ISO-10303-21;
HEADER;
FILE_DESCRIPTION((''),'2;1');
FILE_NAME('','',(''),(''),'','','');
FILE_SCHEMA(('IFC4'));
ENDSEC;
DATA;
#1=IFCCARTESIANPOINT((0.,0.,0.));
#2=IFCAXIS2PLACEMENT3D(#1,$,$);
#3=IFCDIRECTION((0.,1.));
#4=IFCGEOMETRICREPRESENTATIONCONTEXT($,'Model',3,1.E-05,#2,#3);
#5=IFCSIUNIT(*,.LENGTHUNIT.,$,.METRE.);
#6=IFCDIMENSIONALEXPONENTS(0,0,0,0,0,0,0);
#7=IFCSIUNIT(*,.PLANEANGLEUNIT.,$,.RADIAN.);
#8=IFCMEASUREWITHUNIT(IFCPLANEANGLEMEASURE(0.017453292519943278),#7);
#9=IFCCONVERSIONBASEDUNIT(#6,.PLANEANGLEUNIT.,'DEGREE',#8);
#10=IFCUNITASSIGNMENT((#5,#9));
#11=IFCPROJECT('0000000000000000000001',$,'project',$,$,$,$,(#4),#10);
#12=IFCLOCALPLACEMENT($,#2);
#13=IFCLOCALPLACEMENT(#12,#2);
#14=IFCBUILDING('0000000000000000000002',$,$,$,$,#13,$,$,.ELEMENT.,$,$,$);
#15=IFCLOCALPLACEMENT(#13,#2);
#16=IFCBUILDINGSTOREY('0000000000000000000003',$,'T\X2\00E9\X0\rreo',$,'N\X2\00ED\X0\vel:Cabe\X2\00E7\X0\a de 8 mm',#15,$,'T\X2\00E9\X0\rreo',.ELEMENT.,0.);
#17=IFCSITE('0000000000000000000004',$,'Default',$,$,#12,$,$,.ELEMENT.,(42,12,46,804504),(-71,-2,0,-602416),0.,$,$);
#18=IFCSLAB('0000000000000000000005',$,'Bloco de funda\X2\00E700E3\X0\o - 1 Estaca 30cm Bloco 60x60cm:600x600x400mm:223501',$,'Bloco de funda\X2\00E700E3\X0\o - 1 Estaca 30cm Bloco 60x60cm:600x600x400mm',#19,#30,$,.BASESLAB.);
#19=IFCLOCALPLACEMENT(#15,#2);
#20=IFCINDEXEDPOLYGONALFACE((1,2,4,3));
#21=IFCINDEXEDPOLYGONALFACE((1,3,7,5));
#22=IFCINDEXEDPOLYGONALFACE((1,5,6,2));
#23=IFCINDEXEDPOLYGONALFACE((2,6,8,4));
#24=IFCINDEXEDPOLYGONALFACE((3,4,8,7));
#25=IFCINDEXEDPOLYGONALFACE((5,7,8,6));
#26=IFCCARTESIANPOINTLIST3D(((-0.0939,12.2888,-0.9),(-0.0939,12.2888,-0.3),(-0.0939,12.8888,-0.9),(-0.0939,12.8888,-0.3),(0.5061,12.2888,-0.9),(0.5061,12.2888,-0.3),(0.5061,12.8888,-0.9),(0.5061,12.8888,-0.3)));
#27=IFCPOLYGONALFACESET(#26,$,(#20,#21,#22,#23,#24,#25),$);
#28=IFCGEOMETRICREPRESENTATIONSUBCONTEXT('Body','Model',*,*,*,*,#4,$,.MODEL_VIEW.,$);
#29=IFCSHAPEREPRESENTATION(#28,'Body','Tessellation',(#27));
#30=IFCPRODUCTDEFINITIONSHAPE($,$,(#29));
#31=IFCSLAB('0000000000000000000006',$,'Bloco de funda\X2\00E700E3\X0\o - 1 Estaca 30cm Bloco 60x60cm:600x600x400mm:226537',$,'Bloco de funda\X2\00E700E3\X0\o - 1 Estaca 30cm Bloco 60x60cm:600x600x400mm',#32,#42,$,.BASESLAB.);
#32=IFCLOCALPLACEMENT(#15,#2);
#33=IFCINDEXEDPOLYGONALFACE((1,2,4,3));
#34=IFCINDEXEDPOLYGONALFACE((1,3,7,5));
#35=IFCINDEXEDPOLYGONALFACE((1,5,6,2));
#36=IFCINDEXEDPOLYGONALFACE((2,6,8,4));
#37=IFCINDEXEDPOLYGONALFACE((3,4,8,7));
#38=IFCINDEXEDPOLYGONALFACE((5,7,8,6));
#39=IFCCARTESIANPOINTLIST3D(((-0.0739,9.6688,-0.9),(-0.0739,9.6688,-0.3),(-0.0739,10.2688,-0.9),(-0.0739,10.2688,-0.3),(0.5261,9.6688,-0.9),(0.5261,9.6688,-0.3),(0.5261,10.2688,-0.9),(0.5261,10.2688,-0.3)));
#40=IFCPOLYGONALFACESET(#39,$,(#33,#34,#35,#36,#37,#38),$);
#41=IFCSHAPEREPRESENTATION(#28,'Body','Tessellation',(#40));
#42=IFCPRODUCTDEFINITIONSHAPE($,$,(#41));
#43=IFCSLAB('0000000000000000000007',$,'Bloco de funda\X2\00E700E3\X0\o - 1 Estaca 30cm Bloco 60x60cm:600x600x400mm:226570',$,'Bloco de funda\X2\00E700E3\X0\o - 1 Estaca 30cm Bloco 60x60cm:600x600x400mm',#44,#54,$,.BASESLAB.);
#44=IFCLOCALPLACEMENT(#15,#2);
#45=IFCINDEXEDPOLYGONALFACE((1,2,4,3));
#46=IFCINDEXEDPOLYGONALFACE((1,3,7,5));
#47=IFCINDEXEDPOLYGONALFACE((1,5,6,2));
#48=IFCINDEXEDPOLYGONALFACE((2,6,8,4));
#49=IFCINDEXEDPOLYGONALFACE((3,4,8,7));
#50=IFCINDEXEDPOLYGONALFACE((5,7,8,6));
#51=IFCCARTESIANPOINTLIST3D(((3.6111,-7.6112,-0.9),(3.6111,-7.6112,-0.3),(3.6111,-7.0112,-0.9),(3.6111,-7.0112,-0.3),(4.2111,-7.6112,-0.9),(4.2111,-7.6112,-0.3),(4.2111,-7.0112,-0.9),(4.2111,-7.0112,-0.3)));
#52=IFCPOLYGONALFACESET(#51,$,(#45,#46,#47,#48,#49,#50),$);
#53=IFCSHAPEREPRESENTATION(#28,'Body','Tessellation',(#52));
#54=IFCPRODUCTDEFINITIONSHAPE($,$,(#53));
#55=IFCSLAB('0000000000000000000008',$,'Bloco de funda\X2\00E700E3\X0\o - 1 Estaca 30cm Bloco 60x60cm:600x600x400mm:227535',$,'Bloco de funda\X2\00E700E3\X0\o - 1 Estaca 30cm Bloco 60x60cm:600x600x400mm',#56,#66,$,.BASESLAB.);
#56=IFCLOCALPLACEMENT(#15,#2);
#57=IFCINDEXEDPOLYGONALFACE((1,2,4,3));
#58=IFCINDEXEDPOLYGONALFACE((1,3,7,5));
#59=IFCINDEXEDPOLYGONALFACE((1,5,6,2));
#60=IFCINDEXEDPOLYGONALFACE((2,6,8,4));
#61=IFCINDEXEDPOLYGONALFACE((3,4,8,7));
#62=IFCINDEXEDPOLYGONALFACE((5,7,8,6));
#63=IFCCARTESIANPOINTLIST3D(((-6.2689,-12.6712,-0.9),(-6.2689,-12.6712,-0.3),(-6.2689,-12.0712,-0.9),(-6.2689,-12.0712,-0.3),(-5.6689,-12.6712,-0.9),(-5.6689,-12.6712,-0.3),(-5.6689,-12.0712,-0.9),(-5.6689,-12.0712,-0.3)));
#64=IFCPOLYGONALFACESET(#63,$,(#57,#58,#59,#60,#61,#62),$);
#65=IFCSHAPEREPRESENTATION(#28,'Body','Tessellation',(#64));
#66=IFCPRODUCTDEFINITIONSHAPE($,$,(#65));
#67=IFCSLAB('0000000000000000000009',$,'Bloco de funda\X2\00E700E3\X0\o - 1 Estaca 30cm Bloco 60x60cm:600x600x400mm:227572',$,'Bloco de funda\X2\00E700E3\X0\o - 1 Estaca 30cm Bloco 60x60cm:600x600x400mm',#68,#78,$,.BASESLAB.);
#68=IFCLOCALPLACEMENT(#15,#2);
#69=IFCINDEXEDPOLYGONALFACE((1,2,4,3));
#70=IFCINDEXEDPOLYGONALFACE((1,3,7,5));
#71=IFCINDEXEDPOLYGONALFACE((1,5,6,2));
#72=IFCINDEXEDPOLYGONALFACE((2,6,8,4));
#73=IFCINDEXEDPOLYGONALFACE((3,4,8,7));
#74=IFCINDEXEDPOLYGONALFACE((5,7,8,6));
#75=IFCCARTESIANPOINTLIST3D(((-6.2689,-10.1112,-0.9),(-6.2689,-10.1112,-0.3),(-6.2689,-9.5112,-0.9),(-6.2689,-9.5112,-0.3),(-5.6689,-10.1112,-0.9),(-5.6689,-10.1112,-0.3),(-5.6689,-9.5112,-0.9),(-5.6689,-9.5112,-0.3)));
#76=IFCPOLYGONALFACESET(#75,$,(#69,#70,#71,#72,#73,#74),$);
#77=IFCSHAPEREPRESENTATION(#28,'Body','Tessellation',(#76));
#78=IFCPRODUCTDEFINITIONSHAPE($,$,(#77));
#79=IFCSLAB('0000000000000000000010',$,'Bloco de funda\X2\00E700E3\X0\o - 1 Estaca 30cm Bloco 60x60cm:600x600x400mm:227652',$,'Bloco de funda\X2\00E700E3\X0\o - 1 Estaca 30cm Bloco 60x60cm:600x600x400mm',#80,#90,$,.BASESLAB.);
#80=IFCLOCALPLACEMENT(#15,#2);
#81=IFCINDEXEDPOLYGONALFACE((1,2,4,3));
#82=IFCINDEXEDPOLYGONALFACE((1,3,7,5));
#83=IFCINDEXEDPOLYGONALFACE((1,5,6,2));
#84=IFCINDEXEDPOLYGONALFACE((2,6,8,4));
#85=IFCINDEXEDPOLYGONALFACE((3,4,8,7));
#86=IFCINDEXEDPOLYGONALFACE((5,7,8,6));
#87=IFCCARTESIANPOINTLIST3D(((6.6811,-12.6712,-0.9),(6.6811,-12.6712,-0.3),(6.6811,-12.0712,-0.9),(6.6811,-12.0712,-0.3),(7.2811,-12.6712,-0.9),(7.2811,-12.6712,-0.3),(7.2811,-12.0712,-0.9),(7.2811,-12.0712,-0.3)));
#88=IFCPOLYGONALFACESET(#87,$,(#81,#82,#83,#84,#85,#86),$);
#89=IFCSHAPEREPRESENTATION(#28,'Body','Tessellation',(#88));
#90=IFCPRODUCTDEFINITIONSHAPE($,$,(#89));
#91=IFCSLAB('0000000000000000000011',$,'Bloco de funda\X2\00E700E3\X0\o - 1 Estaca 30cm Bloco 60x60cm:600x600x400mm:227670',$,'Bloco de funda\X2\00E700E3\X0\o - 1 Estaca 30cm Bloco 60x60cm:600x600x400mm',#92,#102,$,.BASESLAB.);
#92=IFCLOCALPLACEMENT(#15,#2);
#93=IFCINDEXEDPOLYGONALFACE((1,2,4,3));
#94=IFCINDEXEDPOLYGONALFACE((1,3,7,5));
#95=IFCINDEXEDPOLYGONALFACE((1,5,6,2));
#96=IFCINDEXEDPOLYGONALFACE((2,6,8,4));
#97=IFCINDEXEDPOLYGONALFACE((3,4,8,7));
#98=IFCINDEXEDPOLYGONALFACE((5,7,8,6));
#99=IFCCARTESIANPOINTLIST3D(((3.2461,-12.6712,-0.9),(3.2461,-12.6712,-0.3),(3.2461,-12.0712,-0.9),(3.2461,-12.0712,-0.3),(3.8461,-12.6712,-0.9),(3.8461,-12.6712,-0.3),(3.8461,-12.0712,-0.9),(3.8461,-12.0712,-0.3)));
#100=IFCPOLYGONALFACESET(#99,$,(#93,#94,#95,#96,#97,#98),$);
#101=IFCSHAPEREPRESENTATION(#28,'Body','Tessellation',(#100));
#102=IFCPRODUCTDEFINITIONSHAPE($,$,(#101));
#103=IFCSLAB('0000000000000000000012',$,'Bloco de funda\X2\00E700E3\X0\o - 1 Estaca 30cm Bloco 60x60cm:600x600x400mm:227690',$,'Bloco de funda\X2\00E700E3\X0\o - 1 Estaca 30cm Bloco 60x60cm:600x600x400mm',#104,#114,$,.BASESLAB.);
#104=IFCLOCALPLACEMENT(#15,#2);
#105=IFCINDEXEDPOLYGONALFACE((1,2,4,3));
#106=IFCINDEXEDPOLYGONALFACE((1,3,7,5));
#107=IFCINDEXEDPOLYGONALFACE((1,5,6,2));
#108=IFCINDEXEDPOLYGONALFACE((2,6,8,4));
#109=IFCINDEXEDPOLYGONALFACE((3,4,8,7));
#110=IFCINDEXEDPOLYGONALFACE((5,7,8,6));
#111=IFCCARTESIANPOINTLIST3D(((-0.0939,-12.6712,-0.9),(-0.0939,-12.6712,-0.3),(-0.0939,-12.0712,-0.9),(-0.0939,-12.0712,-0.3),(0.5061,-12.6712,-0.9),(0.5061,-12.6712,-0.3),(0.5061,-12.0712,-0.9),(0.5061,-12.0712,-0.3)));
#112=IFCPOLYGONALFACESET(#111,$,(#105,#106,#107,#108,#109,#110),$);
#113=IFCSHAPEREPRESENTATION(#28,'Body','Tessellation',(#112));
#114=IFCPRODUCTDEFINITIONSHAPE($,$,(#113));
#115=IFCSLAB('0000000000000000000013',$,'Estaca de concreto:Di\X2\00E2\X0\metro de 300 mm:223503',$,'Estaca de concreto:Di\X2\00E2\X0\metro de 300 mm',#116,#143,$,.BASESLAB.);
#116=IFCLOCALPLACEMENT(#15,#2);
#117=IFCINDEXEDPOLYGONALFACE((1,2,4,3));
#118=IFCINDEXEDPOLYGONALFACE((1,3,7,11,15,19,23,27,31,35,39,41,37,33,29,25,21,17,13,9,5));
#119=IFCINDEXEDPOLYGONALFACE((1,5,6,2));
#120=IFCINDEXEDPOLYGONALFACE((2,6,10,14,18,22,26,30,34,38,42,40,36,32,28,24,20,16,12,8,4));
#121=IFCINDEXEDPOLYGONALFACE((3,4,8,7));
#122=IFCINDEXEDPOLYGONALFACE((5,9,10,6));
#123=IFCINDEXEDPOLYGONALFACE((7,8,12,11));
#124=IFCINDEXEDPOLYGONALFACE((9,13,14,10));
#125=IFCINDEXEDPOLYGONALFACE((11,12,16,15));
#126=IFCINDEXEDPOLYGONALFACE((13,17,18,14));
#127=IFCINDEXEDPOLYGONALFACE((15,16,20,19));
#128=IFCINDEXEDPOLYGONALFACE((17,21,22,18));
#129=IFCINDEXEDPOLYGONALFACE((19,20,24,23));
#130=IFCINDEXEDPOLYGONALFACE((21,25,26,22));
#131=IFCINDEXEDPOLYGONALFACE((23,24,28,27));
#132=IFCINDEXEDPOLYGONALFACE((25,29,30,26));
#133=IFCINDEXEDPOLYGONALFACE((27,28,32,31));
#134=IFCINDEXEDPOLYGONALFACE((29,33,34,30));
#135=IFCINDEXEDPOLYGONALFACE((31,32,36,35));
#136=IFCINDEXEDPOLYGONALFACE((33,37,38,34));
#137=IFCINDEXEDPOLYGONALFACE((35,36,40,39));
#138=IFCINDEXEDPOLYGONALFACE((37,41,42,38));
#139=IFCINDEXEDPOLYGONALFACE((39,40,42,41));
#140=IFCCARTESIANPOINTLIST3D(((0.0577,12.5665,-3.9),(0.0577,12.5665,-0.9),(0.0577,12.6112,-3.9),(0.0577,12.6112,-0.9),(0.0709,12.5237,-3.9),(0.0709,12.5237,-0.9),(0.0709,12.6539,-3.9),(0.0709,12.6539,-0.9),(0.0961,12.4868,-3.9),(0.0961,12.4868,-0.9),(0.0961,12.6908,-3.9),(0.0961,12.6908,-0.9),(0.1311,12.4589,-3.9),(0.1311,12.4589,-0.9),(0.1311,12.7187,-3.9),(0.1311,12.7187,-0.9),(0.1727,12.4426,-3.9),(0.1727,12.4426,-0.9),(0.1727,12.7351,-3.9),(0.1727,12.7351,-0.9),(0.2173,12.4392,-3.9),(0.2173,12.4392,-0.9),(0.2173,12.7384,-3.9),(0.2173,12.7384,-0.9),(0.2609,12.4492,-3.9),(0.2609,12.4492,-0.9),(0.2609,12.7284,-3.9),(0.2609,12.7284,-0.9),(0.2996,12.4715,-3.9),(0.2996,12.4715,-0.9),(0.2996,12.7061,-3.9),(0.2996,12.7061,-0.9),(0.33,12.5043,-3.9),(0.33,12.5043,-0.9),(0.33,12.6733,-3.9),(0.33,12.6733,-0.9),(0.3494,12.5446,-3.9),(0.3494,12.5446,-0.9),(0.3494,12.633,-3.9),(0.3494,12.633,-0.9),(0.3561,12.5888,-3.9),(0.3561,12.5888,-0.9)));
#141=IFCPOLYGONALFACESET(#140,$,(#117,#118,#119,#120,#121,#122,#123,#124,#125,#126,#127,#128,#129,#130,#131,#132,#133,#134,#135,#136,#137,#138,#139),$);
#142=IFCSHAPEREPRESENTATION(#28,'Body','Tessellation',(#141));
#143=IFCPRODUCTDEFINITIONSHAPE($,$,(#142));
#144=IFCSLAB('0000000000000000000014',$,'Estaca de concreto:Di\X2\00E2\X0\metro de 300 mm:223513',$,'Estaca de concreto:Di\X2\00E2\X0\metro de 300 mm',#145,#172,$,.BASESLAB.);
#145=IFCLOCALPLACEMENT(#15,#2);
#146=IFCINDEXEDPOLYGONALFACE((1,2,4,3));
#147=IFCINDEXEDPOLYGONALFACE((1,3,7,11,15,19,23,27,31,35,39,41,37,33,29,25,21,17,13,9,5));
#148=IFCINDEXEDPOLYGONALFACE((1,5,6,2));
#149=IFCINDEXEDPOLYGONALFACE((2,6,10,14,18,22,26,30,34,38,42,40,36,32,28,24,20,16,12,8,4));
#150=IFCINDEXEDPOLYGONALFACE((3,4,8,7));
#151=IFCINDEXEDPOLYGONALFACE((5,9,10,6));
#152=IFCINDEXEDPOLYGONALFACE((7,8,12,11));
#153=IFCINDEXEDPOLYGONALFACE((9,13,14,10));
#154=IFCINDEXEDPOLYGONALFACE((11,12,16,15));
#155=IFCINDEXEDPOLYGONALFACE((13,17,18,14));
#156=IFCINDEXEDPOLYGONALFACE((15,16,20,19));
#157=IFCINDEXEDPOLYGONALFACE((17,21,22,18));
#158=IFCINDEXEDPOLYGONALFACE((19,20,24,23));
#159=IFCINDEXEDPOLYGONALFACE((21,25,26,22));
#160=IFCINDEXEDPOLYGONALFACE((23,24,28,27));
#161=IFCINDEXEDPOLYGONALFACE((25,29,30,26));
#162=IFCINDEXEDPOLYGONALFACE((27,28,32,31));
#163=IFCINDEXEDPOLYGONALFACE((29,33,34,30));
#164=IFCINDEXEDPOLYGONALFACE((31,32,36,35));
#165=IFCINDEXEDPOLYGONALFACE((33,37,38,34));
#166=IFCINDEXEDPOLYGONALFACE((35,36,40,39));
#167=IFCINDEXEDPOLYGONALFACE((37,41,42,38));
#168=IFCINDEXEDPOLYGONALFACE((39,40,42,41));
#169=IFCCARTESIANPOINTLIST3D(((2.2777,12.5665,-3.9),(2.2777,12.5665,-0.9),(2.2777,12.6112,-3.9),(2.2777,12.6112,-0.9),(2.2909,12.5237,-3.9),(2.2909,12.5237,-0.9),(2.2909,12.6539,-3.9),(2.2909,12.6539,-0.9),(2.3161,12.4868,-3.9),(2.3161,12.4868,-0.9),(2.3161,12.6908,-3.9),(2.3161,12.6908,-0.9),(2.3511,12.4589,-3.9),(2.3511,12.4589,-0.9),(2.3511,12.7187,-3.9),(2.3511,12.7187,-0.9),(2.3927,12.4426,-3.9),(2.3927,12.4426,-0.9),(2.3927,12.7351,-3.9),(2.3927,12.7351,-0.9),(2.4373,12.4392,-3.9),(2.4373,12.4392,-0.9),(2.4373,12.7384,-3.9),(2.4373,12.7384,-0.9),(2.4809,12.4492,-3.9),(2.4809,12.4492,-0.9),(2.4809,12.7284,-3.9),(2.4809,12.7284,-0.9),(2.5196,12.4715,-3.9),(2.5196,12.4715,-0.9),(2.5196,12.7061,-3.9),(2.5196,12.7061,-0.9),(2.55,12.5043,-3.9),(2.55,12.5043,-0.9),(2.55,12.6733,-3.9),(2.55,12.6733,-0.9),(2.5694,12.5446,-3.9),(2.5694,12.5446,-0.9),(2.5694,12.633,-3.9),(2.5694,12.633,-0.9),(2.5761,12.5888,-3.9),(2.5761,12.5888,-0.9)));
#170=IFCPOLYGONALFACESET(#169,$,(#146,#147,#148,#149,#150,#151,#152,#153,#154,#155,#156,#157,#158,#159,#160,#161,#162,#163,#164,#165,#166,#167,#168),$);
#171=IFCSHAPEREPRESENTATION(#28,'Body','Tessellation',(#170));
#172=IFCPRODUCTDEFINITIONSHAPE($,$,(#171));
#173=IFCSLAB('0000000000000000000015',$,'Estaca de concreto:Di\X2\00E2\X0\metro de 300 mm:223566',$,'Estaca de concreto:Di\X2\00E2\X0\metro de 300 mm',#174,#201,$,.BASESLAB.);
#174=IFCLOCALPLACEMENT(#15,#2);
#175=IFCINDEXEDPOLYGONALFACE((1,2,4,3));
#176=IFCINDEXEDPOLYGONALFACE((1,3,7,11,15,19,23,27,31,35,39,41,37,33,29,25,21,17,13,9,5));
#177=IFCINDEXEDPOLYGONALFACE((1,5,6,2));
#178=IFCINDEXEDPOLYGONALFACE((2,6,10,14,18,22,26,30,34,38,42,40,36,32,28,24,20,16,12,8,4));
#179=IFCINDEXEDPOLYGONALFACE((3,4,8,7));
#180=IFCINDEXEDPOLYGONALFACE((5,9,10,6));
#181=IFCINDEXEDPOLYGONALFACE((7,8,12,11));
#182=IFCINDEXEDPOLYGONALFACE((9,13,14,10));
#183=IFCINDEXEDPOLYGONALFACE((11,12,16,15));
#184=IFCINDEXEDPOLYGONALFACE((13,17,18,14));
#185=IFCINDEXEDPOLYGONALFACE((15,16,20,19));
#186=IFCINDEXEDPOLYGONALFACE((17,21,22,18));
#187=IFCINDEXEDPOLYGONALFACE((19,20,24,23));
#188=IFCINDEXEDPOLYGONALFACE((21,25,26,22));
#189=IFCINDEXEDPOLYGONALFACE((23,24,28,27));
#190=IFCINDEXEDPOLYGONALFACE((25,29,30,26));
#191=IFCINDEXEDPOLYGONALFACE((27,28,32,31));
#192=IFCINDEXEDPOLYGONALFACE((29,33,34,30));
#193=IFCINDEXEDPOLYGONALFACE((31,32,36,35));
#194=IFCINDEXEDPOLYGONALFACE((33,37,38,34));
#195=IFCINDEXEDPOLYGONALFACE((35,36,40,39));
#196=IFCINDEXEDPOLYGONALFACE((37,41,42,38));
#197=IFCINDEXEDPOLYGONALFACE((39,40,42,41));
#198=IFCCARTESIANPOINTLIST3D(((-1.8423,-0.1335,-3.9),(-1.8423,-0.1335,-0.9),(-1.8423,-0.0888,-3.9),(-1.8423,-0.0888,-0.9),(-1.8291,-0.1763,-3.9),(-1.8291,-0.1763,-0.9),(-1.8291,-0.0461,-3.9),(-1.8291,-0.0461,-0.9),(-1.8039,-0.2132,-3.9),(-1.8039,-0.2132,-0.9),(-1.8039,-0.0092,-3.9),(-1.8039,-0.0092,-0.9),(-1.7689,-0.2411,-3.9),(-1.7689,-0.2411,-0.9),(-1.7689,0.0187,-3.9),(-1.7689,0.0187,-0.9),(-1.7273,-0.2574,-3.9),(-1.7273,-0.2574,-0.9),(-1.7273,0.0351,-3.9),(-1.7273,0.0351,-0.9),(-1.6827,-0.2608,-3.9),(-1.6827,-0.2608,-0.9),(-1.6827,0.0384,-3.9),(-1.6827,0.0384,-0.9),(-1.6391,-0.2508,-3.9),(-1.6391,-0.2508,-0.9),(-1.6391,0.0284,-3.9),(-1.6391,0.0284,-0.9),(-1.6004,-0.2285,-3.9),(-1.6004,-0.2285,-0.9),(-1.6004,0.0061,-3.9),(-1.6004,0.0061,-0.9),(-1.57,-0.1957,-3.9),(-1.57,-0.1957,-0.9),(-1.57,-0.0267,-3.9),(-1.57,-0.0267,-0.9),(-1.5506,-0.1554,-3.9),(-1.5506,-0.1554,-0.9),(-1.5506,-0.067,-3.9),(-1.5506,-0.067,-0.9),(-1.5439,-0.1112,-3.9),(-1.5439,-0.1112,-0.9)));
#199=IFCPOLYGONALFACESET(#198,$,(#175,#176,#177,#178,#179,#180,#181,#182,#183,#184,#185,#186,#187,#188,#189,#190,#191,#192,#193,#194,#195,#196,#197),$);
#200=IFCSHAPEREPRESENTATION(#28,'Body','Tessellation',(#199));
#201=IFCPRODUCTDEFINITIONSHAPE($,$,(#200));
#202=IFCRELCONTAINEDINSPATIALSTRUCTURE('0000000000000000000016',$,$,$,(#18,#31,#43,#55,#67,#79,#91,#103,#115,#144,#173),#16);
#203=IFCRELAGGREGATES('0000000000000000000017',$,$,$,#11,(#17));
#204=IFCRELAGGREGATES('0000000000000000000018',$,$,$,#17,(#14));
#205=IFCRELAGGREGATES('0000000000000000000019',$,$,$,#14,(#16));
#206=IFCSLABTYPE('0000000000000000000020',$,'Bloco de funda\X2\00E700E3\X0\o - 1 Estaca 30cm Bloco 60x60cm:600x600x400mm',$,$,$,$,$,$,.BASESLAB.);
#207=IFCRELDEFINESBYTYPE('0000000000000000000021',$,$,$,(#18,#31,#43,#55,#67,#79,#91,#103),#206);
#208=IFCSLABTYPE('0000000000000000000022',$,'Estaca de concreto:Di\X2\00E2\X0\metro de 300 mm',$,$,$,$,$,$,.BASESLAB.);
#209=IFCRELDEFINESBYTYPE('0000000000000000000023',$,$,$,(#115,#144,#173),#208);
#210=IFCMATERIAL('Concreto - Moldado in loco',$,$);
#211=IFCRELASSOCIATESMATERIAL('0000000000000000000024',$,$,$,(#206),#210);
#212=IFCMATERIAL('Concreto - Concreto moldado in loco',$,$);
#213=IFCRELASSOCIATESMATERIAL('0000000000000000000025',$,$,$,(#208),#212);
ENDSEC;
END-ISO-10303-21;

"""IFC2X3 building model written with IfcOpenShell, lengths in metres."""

from ifc_helpers import new_model, entity, si_unit, converted_unit, direction, frame, frame_2d, origin, origin_2d_with_axis, place, context, subcontext, project, spatial, rectangle, circle, extrude, material, type_object, element, save


model = new_model("IFC2X3")

# Units and contexts
model_context = context("Model", 3, precision=1e-05, world=origin(), true_north=direction((0.0, 1.0)))
body_context = subcontext(model_context, "Body", "Model", "MODEL_VIEW")
ifc_project = project(units=[si_unit("LENGTHUNIT", "METRE"), converted_unit("PLANEANGLEUNIT", "DEGREE", entity("IfcPlaneAngleMeasure", 0.017453292519943278), si_unit("PLANEANGLEUNIT", "RADIAN"), dimensions=[0, 0, 0, 0, 0, 0, 0])], contexts=[model_context])

# Site, building, storey
site_placement = place(None, origin())
site = spatial("IfcSite", under=ifc_project, at=site_placement, Name="Default", CompositionType="ELEMENT", RefLatitude=(42, 12, 46, 804504), RefLongitude=(-71, -2, 0, -602416), RefElevation=0.0)
building_placement = place(site_placement, origin())
building = spatial("IfcBuilding", under=site, at=building_placement, CompositionType="ELEMENT")
storey_placement = place(building_placement, origin())
storey = spatial("IfcBuildingStorey", under=building, at=storey_placement, Name="Térreo", ObjectType="Nível:Cabeça de 8 mm", LongName="Térreo", CompositionType="ELEMENT", Elevation=0.0)

# Slabs
ifc_material_1 = material(Name="Concreto - Moldado in loco")
slab_type_1 = type_object("IfcSlabType", Name="Bloco de fundação - 1 Estaca 30cm Bloco 60x60cm:600x600x400mm", PredefinedType="BASESLAB", material=ifc_material_1)
slab_1_placement = place(storey_placement, origin())
element("IfcSlab", 1, at=slab_1_placement, inside=storey, type_object=slab_type_1, Name="Bloco de fundação - 1 Estaca 30cm Bloco 60x60cm:600x600x400mm:223501", ObjectType="Bloco de fundação - 1 Estaca 30cm Bloco 60x60cm:600x600x400mm", PredefinedType="BASESLAB", context=body_context, shape_type="SweptSolid", body=[
    extrude(rectangle(XDim=0.6, YDim=0.6, at=frame_2d((0.0, 0.0), x_axis=(1.0, 0.0))), frame((0.2061, 12.5888, -0.9), z_axis=(0.0, 0.0, 1.0), x_axis=(-1.0, 0.0, 0.0)), (0.0, 0.0, 1.0), 0.6),
])
slab_2_placement = place(storey_placement, origin())
element("IfcSlab", 2, at=slab_2_placement, inside=storey, type_object=slab_type_1, Name="Bloco de fundação - 1 Estaca 30cm Bloco 60x60cm:600x600x400mm:226537", ObjectType="Bloco de fundação - 1 Estaca 30cm Bloco 60x60cm:600x600x400mm", PredefinedType="BASESLAB", context=body_context, shape_type="SweptSolid", body=[
    extrude(rectangle(XDim=0.6, YDim=0.6, at=frame_2d((0.0, 0.0), x_axis=(1.0, 0.0))), frame((0.2261, 9.9688, -0.9), z_axis=(0.0, 0.0, 1.0), x_axis=(-1.0, 0.0, 0.0)), (0.0, 0.0, 1.0), 0.6),
])
slab_3_placement = place(storey_placement, origin())
element("IfcSlab", 3, at=slab_3_placement, inside=storey, type_object=slab_type_1, Name="Bloco de fundação - 1 Estaca 30cm Bloco 60x60cm:600x600x400mm:226570", ObjectType="Bloco de fundação - 1 Estaca 30cm Bloco 60x60cm:600x600x400mm", PredefinedType="BASESLAB", context=body_context, shape_type="SweptSolid", body=[
    extrude(rectangle(XDim=0.6, YDim=0.6, at=frame_2d((0.0, 0.0), x_axis=(1.0, 0.0))), frame((3.9111, -7.3112, -0.9), z_axis=(0.0, 0.0, 1.0), x_axis=(-1.0, 0.0, 0.0)), (0.0, 0.0, 1.0), 0.6),
])
slab_4_placement = place(storey_placement, origin())
element("IfcSlab", 4, at=slab_4_placement, inside=storey, type_object=slab_type_1, Name="Bloco de fundação - 1 Estaca 30cm Bloco 60x60cm:600x600x400mm:227535", ObjectType="Bloco de fundação - 1 Estaca 30cm Bloco 60x60cm:600x600x400mm", PredefinedType="BASESLAB", context=body_context, shape_type="SweptSolid", body=[
    extrude(rectangle(XDim=0.6, YDim=0.6, at=frame_2d((0.0, 0.0), x_axis=(1.0, 0.0))), frame((-5.9689, -12.3712, -0.9), z_axis=(0.0, 0.0, 1.0), x_axis=(-1.0, 0.0, 0.0)), (0.0, 0.0, 1.0), 0.6),
])
slab_5_placement = place(storey_placement, origin())
element("IfcSlab", 5, at=slab_5_placement, inside=storey, type_object=slab_type_1, Name="Bloco de fundação - 1 Estaca 30cm Bloco 60x60cm:600x600x400mm:227572", ObjectType="Bloco de fundação - 1 Estaca 30cm Bloco 60x60cm:600x600x400mm", PredefinedType="BASESLAB", context=body_context, shape_type="SweptSolid", body=[
    extrude(rectangle(XDim=0.6, YDim=0.6, at=frame_2d((0.0, 0.0), x_axis=(1.0, 0.0))), frame((-5.9689, -9.8112, -0.9), z_axis=(0.0, 0.0, 1.0), x_axis=(-1.0, 0.0, 0.0)), (0.0, 0.0, 1.0), 0.6),
])
slab_6_placement = place(storey_placement, origin())
element("IfcSlab", 6, at=slab_6_placement, inside=storey, type_object=slab_type_1, Name="Bloco de fundação - 1 Estaca 30cm Bloco 60x60cm:600x600x400mm:227652", ObjectType="Bloco de fundação - 1 Estaca 30cm Bloco 60x60cm:600x600x400mm", PredefinedType="BASESLAB", context=body_context, shape_type="SweptSolid", body=[
    extrude(rectangle(XDim=0.6, YDim=0.6, at=frame_2d((0.0, 0.0), x_axis=(1.0, 0.0))), frame((6.9811, -12.3712, -0.9), z_axis=(0.0, 0.0, 1.0), x_axis=(-1.0, 0.0, 0.0)), (0.0, 0.0, 1.0), 0.6),
])
slab_7_placement = place(storey_placement, origin())
element("IfcSlab", 7, at=slab_7_placement, inside=storey, type_object=slab_type_1, Name="Bloco de fundação - 1 Estaca 30cm Bloco 60x60cm:600x600x400mm:227670", ObjectType="Bloco de fundação - 1 Estaca 30cm Bloco 60x60cm:600x600x400mm", PredefinedType="BASESLAB", context=body_context, shape_type="SweptSolid", body=[
    extrude(rectangle(XDim=0.6, YDim=0.6, at=frame_2d((0.0, 0.0), x_axis=(1.0, 0.0))), frame((3.5461, -12.3712, -0.9), z_axis=(0.0, 0.0, 1.0), x_axis=(-1.0, 0.0, 0.0)), (0.0, 0.0, 1.0), 0.6),
])
slab_8_placement = place(storey_placement, origin())
element("IfcSlab", 8, at=slab_8_placement, inside=storey, type_object=slab_type_1, Name="Bloco de fundação - 1 Estaca 30cm Bloco 60x60cm:600x600x400mm:227690", ObjectType="Bloco de fundação - 1 Estaca 30cm Bloco 60x60cm:600x600x400mm", PredefinedType="BASESLAB", context=body_context, shape_type="SweptSolid", body=[
    extrude(rectangle(XDim=0.6, YDim=0.6, at=frame_2d((0.0, 0.0), x_axis=(1.0, 0.0))), frame((0.2061, -12.3712, -0.9), z_axis=(0.0, 0.0, 1.0), x_axis=(-1.0, 0.0, 0.0)), (0.0, 0.0, 1.0), 0.6),
])
ifc_material_2 = material(Name="Concreto - Concreto moldado in loco")
slab_type_2 = type_object("IfcSlabType", Name="Estaca de concreto:Diâmetro de 300 mm", PredefinedType="BASESLAB", material=ifc_material_2)
slab_9_placement = place(storey_placement, origin())
element("IfcSlab", 9, at=slab_9_placement, inside=storey, type_object=slab_type_2, Name="Estaca de concreto:Diâmetro de 300 mm:223503", ObjectType="Estaca de concreto:Diâmetro de 300 mm", PredefinedType="BASESLAB", context=body_context, shape_type="SweptSolid", body=[
    extrude(circle(Radius=0.15, at=origin_2d_with_axis()), frame((0.2061, 12.5888, -3.9)), (0.0, 0.0, 1.0), 3.0),
])
slab_10_placement = place(storey_placement, origin())
element("IfcSlab", 10, at=slab_10_placement, inside=storey, type_object=slab_type_2, Name="Estaca de concreto:Diâmetro de 300 mm:223513", ObjectType="Estaca de concreto:Diâmetro de 300 mm", PredefinedType="BASESLAB", context=body_context, shape_type="SweptSolid", body=[
    extrude(circle(Radius=0.15, at=origin_2d_with_axis()), frame((2.4261, 12.5888, -3.9)), (0.0, 0.0, 1.0), 3.0),
])
slab_11_placement = place(storey_placement, origin())
element("IfcSlab", 11, at=slab_11_placement, inside=storey, type_object=slab_type_2, Name="Estaca de concreto:Diâmetro de 300 mm:223566", ObjectType="Estaca de concreto:Diâmetro de 300 mm", PredefinedType="BASESLAB", context=body_context, shape_type="SweptSolid", body=[
    extrude(circle(Radius=0.15, at=frame_2d((0.0, 0.0), x_axis=(1.0, 0.0))), frame((-1.6939, -0.1112, -3.9)), (0.0, 0.0, 1.0), 3.0),
])

save(model, "model.ifc")
